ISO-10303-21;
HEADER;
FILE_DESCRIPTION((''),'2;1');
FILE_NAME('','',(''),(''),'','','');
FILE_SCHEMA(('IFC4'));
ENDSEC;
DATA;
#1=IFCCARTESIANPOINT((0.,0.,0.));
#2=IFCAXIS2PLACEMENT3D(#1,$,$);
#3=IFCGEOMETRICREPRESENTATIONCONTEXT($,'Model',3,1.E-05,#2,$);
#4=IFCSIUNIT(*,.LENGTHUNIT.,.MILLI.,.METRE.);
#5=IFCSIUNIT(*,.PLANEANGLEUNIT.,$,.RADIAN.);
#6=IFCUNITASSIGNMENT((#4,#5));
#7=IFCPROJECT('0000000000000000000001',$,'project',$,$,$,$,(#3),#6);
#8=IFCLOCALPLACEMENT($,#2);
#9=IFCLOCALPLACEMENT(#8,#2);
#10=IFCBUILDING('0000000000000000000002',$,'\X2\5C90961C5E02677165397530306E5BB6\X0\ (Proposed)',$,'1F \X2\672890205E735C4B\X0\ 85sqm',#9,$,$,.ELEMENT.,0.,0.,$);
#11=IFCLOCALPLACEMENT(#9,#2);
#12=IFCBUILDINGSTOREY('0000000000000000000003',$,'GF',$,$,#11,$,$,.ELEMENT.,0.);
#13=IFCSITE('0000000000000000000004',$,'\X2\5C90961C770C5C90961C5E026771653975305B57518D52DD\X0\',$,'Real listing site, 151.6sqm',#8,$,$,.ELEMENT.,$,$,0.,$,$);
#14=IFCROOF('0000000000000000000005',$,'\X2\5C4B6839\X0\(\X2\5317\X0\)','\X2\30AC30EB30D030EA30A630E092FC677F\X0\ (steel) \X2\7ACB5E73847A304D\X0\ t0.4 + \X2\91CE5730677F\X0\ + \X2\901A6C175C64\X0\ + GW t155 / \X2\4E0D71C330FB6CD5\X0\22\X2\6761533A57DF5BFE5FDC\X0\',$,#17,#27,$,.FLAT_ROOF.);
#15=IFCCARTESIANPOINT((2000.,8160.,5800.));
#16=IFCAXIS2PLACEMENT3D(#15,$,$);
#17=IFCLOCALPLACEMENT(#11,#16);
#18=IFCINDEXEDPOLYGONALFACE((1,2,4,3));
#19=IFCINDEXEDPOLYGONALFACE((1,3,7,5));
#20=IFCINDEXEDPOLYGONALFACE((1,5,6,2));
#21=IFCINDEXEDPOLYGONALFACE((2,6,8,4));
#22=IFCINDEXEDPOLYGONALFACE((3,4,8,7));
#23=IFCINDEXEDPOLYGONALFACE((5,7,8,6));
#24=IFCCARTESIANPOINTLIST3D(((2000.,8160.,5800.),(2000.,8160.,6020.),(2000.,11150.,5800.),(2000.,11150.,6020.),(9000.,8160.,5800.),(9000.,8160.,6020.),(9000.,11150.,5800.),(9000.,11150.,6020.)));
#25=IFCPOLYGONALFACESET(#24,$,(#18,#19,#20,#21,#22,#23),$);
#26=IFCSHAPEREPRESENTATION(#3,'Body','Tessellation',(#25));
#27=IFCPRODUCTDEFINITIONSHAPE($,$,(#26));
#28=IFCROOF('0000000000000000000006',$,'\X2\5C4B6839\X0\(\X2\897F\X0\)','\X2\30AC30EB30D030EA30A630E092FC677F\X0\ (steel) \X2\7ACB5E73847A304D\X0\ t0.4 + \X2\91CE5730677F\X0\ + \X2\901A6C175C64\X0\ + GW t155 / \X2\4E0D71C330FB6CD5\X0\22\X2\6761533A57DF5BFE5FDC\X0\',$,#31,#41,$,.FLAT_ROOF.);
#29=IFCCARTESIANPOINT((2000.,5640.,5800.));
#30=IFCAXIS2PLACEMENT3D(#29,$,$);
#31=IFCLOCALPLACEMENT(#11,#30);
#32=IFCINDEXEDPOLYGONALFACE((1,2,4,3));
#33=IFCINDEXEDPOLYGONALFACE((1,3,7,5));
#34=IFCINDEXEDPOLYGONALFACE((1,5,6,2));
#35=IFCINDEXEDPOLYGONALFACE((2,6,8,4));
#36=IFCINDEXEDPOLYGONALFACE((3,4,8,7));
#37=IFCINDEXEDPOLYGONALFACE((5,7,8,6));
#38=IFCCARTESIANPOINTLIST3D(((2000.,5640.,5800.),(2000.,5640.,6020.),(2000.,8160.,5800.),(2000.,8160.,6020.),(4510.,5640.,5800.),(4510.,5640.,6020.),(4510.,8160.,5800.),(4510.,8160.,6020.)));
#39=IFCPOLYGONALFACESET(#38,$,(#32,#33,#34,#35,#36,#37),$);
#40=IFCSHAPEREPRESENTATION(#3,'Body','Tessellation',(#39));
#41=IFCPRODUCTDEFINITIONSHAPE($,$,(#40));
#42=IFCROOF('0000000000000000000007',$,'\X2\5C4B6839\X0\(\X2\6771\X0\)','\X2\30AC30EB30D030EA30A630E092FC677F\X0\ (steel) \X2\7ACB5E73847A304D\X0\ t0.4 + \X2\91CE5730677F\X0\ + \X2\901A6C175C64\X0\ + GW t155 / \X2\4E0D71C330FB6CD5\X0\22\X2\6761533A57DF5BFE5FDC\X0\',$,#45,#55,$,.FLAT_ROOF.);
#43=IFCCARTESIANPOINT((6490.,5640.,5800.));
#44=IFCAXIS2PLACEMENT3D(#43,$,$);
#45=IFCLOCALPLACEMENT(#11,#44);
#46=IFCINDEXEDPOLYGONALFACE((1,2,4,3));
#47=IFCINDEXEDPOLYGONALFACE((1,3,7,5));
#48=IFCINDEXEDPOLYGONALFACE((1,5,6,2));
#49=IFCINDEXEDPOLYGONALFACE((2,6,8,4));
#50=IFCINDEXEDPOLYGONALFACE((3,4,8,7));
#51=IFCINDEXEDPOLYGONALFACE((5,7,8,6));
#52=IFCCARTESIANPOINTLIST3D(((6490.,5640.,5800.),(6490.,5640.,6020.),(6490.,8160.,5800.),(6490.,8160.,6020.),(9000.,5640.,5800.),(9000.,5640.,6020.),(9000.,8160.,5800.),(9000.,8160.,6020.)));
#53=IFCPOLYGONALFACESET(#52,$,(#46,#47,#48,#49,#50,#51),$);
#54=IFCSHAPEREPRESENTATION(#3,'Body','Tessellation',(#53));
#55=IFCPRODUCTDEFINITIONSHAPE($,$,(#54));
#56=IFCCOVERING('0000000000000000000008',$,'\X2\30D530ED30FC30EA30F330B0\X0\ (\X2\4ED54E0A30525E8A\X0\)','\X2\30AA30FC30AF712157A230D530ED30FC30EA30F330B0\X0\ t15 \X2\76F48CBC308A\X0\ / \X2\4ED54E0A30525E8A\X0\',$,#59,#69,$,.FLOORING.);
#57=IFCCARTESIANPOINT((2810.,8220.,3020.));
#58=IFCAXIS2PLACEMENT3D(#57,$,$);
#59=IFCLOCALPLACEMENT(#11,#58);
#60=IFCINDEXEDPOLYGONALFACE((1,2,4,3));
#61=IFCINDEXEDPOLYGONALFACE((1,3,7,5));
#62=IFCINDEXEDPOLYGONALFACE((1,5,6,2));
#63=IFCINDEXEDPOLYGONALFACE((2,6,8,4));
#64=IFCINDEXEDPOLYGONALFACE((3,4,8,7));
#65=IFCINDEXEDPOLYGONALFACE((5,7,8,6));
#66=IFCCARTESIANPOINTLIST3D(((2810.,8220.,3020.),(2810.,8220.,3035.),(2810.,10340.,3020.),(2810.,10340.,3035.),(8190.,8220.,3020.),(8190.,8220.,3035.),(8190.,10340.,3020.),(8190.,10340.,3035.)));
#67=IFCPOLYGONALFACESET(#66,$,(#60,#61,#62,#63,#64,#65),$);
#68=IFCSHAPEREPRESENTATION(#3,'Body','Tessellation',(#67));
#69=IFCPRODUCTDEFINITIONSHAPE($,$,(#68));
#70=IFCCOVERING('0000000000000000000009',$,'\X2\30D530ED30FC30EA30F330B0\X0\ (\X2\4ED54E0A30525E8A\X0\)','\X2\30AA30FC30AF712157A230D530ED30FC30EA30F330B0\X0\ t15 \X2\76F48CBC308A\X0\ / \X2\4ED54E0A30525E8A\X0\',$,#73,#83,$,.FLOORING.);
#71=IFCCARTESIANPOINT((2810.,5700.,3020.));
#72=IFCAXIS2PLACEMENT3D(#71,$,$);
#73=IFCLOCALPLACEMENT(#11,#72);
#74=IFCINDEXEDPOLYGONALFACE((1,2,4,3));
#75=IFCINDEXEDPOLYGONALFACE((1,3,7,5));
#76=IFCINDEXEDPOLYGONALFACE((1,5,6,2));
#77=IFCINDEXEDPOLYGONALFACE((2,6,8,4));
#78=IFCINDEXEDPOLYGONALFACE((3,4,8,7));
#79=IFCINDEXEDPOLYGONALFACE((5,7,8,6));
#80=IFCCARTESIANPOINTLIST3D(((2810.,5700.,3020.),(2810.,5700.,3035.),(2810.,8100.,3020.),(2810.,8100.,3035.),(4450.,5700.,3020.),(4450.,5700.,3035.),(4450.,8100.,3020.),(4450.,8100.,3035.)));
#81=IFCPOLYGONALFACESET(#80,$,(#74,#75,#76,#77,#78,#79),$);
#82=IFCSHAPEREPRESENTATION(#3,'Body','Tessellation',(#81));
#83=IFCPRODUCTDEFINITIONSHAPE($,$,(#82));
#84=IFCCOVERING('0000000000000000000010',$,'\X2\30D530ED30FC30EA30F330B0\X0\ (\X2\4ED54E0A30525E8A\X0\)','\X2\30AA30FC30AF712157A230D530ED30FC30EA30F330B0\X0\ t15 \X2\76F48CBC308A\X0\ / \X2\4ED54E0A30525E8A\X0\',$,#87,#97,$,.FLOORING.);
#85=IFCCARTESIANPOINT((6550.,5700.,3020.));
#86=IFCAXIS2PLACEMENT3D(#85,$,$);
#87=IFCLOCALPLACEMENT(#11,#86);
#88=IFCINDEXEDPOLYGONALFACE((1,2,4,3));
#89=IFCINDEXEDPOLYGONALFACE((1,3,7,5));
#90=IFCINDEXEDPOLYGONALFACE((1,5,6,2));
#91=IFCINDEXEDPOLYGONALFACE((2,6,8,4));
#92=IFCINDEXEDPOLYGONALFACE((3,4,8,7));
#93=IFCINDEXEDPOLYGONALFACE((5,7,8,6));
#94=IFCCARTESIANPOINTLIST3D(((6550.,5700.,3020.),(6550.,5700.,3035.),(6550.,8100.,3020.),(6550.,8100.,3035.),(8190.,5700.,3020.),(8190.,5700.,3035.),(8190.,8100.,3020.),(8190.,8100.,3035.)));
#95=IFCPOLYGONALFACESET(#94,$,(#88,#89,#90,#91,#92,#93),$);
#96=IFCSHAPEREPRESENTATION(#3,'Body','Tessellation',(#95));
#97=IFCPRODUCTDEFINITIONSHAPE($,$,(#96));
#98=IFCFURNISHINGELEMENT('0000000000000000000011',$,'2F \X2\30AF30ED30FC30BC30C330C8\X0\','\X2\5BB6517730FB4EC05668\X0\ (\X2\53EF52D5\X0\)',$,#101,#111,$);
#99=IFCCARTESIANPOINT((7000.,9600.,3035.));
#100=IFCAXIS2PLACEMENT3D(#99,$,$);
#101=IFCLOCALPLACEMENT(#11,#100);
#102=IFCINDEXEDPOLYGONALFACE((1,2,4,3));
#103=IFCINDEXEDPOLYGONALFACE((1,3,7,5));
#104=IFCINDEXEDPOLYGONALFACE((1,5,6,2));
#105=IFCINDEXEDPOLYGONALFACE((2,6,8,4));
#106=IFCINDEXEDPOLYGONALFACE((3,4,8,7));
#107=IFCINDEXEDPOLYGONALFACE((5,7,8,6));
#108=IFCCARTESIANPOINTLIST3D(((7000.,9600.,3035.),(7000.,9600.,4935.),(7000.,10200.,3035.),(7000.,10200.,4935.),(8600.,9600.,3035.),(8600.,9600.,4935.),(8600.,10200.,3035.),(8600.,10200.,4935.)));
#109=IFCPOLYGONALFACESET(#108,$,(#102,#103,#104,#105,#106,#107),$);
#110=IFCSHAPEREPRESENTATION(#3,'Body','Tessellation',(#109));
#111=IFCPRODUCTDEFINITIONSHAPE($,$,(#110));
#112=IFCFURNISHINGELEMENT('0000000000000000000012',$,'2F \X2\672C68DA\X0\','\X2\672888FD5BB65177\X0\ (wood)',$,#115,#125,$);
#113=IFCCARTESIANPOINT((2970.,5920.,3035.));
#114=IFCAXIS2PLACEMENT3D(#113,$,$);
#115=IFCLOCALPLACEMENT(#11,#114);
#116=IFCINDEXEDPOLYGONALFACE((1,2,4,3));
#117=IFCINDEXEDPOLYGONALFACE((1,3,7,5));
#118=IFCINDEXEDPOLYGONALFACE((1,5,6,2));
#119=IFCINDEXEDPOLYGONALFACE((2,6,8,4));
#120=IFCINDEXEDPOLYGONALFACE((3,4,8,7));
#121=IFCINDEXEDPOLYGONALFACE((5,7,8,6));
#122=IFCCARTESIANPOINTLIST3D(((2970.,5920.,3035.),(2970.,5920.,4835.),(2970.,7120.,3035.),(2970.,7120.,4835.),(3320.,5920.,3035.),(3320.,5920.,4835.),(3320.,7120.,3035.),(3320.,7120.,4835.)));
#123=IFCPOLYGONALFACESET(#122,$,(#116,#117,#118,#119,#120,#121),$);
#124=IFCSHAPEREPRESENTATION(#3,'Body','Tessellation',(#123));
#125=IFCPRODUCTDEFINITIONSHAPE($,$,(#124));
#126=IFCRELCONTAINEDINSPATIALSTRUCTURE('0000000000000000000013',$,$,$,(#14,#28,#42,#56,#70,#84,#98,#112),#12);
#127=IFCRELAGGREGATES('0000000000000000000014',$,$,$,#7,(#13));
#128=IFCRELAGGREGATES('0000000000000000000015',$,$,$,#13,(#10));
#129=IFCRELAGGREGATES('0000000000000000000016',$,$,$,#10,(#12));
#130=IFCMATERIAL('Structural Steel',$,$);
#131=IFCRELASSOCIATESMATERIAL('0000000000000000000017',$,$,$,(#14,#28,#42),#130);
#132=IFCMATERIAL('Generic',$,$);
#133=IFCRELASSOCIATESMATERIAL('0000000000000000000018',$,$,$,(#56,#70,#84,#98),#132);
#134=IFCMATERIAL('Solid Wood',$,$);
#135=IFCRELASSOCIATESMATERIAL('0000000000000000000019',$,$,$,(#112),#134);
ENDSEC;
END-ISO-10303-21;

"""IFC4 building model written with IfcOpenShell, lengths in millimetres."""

from ifc_helpers import new_model, si_unit, frame, frame_2d, origin, place, context, project, spatial, rectangle, extrude, material, element, save


model = new_model("IFC4")

# Units and contexts
model_context = context("Model", 3, precision=1e-05, world=origin())
ifc_project = project(units=[si_unit("LENGTHUNIT", "METRE", prefix="MILLI"), si_unit("PLANEANGLEUNIT", "RADIAN")], contexts=[model_context])

# Site, building, storey
site_placement = place(None, origin())
site = spatial("IfcSite", under=ifc_project, at=site_placement, Name="岐阜県岐阜市東改田字再勝", ObjectType="Real listing site, 151.6sqm", CompositionType="ELEMENT", RefElevation=0.0)
building_placement = place(site_placement, origin())
building = spatial("IfcBuilding", under=site, at=building_placement, Name="岐阜市東改田の家 (Proposed)", ObjectType="1F 木造平屋 85sqm", CompositionType="ELEMENT", ElevationOfRefHeight=0.0, ElevationOfTerrain=0.0)
storey_placement = place(building_placement, origin())
storey = spatial("IfcBuildingStorey", under=building, at=storey_placement, Name="GF", CompositionType="ELEMENT", Elevation=0.0)

# Shared definitions
ifc_material_1 = material(Name="Solid Wood")

# Shared definitions
ifc_material_2 = material(Name="Generic")

# Roofs
ifc_material_3 = material(Name="Structural Steel")
for number, where, name in (
    (1, (2000.0, 8160.0, 5800.0), "屋根(北)"),
):
    element("IfcRoof", number, at=place(storey_placement, frame(where)), inside=storey, material=ifc_material_3, Name=name, Description="ガルバリウム鋼板 (steel) 立平葺き t0.4 + 野地板 + 通気層 + GW t155 / 不燃・法22条区域対応", PredefinedType="FLAT_ROOF", context=model_context, shape_type="SweptSolid", body=[
        extrude(rectangle(XDim=7000.0, YDim=2990.0, at=frame_2d((3500.0, 1495.0))), frame((2000.0, 8160.0, 5800.0)), (0.0, 0.0, 1.0), 220.0),
    ])
roof_1_placement = place(storey_placement, frame((2000.0, 5640.0, 5800.0)))
element("IfcRoof", 2, at=roof_1_placement, inside=storey, material=ifc_material_3, Name="屋根(西)", Description="ガルバリウム鋼板 (steel) 立平葺き t0.4 + 野地板 + 通気層 + GW t155 / 不燃・法22条区域対応", PredefinedType="FLAT_ROOF", context=model_context, shape_type="SweptSolid", body=[
    extrude(rectangle(XDim=2510.0, YDim=2520.0, at=frame_2d((1255.0, 1260.0))), frame((2000.0, 5640.0, 5800.0)), (0.0, 0.0, 1.0), 220.0),
])
roof_2_placement = place(storey_placement, frame((6490.0, 5640.0, 5800.0)))
element("IfcRoof", 3, at=roof_2_placement, inside=storey, material=ifc_material_3, Name="屋根(東)", Description="ガルバリウム鋼板 (steel) 立平葺き t0.4 + 野地板 + 通気層 + GW t155 / 不燃・法22条区域対応", PredefinedType="FLAT_ROOF", context=model_context, shape_type="SweptSolid", body=[
    extrude(rectangle(XDim=2510.0, YDim=2520.0, at=frame_2d((1255.0, 1260.0))), frame((6490.0, 5640.0, 5800.0)), (0.0, 0.0, 1.0), 220.0),
])

# Coverings
covering_1_placement = place(storey_placement, frame((2810.0, 8220.0, 3020.0)))
element("IfcCovering", 4, at=covering_1_placement, inside=storey, material=ifc_material_2, Name="フローリング (仕上げ床)", Description="オーク無垢フローリング t15 直貼り / 仕上げ床", PredefinedType="FLOORING", context=model_context, shape_type="SweptSolid", body=[
    extrude(rectangle(XDim=5380.0, YDim=2120.0, at=frame_2d((2690.0, 1060.0))), frame((2810.0, 8220.0, 3020.0)), (0.0, 0.0, 1.0), 15.0),
])
covering_2_placement = place(storey_placement, frame((2810.0, 5700.0, 3020.0)))
element("IfcCovering", 5, at=covering_2_placement, inside=storey, material=ifc_material_2, Name="フローリング (仕上げ床)", Description="オーク無垢フローリング t15 直貼り / 仕上げ床", PredefinedType="FLOORING", context=model_context, shape_type="SweptSolid", body=[
    extrude(rectangle(XDim=1640.0, YDim=2400.0, at=frame_2d((820.0, 1200.0))), frame((2810.0, 5700.0, 3020.0)), (0.0, 0.0, 1.0), 15.0),
])
covering_3_placement = place(storey_placement, frame((6550.0, 5700.0, 3020.0)))
element("IfcCovering", 6, at=covering_3_placement, inside=storey, material=ifc_material_2, Name="フローリング (仕上げ床)", Description="オーク無垢フローリング t15 直貼り / 仕上げ床", PredefinedType="FLOORING", context=model_context, shape_type="SweptSolid", body=[
    extrude(rectangle(XDim=1640.0, YDim=2400.0, at=frame_2d((820.0, 1200.0))), frame((6550.0, 5700.0, 3020.0)), (0.0, 0.0, 1.0), 15.0),
])

# Furnishing elements
furnishing_1_placement = place(storey_placement, frame((7000.0, 9600.0, 3035.0)))
element("IfcFurnishingElement", 7, at=furnishing_1_placement, inside=storey, material=ifc_material_2, Name="2F クローゼット", Description="家具・什器 (可動)", context=model_context, shape_type="SweptSolid", body=[
    extrude(rectangle(XDim=1600.0, YDim=600.0, at=frame_2d((800.0, 300.0))), frame((7000.0, 9600.0, 3035.0)), (0.0, 0.0, 1.0), 1900.0),
])
furnishing_2_placement = place(storey_placement, frame((2970.0, 5920.0, 3035.0)))
element("IfcFurnishingElement", 8, at=furnishing_2_placement, inside=storey, material=ifc_material_1, Name="2F 本棚", Description="木製家具 (wood)", context=model_context, shape_type="SweptSolid", body=[
    extrude(rectangle(XDim=350.0, YDim=1200.0, at=frame_2d((175.0, 600.0))), frame((2970.0, 5920.0, 3035.0)), (0.0, 0.0, 1.0), 1800.0),
])

save(model, "model.ifc")
